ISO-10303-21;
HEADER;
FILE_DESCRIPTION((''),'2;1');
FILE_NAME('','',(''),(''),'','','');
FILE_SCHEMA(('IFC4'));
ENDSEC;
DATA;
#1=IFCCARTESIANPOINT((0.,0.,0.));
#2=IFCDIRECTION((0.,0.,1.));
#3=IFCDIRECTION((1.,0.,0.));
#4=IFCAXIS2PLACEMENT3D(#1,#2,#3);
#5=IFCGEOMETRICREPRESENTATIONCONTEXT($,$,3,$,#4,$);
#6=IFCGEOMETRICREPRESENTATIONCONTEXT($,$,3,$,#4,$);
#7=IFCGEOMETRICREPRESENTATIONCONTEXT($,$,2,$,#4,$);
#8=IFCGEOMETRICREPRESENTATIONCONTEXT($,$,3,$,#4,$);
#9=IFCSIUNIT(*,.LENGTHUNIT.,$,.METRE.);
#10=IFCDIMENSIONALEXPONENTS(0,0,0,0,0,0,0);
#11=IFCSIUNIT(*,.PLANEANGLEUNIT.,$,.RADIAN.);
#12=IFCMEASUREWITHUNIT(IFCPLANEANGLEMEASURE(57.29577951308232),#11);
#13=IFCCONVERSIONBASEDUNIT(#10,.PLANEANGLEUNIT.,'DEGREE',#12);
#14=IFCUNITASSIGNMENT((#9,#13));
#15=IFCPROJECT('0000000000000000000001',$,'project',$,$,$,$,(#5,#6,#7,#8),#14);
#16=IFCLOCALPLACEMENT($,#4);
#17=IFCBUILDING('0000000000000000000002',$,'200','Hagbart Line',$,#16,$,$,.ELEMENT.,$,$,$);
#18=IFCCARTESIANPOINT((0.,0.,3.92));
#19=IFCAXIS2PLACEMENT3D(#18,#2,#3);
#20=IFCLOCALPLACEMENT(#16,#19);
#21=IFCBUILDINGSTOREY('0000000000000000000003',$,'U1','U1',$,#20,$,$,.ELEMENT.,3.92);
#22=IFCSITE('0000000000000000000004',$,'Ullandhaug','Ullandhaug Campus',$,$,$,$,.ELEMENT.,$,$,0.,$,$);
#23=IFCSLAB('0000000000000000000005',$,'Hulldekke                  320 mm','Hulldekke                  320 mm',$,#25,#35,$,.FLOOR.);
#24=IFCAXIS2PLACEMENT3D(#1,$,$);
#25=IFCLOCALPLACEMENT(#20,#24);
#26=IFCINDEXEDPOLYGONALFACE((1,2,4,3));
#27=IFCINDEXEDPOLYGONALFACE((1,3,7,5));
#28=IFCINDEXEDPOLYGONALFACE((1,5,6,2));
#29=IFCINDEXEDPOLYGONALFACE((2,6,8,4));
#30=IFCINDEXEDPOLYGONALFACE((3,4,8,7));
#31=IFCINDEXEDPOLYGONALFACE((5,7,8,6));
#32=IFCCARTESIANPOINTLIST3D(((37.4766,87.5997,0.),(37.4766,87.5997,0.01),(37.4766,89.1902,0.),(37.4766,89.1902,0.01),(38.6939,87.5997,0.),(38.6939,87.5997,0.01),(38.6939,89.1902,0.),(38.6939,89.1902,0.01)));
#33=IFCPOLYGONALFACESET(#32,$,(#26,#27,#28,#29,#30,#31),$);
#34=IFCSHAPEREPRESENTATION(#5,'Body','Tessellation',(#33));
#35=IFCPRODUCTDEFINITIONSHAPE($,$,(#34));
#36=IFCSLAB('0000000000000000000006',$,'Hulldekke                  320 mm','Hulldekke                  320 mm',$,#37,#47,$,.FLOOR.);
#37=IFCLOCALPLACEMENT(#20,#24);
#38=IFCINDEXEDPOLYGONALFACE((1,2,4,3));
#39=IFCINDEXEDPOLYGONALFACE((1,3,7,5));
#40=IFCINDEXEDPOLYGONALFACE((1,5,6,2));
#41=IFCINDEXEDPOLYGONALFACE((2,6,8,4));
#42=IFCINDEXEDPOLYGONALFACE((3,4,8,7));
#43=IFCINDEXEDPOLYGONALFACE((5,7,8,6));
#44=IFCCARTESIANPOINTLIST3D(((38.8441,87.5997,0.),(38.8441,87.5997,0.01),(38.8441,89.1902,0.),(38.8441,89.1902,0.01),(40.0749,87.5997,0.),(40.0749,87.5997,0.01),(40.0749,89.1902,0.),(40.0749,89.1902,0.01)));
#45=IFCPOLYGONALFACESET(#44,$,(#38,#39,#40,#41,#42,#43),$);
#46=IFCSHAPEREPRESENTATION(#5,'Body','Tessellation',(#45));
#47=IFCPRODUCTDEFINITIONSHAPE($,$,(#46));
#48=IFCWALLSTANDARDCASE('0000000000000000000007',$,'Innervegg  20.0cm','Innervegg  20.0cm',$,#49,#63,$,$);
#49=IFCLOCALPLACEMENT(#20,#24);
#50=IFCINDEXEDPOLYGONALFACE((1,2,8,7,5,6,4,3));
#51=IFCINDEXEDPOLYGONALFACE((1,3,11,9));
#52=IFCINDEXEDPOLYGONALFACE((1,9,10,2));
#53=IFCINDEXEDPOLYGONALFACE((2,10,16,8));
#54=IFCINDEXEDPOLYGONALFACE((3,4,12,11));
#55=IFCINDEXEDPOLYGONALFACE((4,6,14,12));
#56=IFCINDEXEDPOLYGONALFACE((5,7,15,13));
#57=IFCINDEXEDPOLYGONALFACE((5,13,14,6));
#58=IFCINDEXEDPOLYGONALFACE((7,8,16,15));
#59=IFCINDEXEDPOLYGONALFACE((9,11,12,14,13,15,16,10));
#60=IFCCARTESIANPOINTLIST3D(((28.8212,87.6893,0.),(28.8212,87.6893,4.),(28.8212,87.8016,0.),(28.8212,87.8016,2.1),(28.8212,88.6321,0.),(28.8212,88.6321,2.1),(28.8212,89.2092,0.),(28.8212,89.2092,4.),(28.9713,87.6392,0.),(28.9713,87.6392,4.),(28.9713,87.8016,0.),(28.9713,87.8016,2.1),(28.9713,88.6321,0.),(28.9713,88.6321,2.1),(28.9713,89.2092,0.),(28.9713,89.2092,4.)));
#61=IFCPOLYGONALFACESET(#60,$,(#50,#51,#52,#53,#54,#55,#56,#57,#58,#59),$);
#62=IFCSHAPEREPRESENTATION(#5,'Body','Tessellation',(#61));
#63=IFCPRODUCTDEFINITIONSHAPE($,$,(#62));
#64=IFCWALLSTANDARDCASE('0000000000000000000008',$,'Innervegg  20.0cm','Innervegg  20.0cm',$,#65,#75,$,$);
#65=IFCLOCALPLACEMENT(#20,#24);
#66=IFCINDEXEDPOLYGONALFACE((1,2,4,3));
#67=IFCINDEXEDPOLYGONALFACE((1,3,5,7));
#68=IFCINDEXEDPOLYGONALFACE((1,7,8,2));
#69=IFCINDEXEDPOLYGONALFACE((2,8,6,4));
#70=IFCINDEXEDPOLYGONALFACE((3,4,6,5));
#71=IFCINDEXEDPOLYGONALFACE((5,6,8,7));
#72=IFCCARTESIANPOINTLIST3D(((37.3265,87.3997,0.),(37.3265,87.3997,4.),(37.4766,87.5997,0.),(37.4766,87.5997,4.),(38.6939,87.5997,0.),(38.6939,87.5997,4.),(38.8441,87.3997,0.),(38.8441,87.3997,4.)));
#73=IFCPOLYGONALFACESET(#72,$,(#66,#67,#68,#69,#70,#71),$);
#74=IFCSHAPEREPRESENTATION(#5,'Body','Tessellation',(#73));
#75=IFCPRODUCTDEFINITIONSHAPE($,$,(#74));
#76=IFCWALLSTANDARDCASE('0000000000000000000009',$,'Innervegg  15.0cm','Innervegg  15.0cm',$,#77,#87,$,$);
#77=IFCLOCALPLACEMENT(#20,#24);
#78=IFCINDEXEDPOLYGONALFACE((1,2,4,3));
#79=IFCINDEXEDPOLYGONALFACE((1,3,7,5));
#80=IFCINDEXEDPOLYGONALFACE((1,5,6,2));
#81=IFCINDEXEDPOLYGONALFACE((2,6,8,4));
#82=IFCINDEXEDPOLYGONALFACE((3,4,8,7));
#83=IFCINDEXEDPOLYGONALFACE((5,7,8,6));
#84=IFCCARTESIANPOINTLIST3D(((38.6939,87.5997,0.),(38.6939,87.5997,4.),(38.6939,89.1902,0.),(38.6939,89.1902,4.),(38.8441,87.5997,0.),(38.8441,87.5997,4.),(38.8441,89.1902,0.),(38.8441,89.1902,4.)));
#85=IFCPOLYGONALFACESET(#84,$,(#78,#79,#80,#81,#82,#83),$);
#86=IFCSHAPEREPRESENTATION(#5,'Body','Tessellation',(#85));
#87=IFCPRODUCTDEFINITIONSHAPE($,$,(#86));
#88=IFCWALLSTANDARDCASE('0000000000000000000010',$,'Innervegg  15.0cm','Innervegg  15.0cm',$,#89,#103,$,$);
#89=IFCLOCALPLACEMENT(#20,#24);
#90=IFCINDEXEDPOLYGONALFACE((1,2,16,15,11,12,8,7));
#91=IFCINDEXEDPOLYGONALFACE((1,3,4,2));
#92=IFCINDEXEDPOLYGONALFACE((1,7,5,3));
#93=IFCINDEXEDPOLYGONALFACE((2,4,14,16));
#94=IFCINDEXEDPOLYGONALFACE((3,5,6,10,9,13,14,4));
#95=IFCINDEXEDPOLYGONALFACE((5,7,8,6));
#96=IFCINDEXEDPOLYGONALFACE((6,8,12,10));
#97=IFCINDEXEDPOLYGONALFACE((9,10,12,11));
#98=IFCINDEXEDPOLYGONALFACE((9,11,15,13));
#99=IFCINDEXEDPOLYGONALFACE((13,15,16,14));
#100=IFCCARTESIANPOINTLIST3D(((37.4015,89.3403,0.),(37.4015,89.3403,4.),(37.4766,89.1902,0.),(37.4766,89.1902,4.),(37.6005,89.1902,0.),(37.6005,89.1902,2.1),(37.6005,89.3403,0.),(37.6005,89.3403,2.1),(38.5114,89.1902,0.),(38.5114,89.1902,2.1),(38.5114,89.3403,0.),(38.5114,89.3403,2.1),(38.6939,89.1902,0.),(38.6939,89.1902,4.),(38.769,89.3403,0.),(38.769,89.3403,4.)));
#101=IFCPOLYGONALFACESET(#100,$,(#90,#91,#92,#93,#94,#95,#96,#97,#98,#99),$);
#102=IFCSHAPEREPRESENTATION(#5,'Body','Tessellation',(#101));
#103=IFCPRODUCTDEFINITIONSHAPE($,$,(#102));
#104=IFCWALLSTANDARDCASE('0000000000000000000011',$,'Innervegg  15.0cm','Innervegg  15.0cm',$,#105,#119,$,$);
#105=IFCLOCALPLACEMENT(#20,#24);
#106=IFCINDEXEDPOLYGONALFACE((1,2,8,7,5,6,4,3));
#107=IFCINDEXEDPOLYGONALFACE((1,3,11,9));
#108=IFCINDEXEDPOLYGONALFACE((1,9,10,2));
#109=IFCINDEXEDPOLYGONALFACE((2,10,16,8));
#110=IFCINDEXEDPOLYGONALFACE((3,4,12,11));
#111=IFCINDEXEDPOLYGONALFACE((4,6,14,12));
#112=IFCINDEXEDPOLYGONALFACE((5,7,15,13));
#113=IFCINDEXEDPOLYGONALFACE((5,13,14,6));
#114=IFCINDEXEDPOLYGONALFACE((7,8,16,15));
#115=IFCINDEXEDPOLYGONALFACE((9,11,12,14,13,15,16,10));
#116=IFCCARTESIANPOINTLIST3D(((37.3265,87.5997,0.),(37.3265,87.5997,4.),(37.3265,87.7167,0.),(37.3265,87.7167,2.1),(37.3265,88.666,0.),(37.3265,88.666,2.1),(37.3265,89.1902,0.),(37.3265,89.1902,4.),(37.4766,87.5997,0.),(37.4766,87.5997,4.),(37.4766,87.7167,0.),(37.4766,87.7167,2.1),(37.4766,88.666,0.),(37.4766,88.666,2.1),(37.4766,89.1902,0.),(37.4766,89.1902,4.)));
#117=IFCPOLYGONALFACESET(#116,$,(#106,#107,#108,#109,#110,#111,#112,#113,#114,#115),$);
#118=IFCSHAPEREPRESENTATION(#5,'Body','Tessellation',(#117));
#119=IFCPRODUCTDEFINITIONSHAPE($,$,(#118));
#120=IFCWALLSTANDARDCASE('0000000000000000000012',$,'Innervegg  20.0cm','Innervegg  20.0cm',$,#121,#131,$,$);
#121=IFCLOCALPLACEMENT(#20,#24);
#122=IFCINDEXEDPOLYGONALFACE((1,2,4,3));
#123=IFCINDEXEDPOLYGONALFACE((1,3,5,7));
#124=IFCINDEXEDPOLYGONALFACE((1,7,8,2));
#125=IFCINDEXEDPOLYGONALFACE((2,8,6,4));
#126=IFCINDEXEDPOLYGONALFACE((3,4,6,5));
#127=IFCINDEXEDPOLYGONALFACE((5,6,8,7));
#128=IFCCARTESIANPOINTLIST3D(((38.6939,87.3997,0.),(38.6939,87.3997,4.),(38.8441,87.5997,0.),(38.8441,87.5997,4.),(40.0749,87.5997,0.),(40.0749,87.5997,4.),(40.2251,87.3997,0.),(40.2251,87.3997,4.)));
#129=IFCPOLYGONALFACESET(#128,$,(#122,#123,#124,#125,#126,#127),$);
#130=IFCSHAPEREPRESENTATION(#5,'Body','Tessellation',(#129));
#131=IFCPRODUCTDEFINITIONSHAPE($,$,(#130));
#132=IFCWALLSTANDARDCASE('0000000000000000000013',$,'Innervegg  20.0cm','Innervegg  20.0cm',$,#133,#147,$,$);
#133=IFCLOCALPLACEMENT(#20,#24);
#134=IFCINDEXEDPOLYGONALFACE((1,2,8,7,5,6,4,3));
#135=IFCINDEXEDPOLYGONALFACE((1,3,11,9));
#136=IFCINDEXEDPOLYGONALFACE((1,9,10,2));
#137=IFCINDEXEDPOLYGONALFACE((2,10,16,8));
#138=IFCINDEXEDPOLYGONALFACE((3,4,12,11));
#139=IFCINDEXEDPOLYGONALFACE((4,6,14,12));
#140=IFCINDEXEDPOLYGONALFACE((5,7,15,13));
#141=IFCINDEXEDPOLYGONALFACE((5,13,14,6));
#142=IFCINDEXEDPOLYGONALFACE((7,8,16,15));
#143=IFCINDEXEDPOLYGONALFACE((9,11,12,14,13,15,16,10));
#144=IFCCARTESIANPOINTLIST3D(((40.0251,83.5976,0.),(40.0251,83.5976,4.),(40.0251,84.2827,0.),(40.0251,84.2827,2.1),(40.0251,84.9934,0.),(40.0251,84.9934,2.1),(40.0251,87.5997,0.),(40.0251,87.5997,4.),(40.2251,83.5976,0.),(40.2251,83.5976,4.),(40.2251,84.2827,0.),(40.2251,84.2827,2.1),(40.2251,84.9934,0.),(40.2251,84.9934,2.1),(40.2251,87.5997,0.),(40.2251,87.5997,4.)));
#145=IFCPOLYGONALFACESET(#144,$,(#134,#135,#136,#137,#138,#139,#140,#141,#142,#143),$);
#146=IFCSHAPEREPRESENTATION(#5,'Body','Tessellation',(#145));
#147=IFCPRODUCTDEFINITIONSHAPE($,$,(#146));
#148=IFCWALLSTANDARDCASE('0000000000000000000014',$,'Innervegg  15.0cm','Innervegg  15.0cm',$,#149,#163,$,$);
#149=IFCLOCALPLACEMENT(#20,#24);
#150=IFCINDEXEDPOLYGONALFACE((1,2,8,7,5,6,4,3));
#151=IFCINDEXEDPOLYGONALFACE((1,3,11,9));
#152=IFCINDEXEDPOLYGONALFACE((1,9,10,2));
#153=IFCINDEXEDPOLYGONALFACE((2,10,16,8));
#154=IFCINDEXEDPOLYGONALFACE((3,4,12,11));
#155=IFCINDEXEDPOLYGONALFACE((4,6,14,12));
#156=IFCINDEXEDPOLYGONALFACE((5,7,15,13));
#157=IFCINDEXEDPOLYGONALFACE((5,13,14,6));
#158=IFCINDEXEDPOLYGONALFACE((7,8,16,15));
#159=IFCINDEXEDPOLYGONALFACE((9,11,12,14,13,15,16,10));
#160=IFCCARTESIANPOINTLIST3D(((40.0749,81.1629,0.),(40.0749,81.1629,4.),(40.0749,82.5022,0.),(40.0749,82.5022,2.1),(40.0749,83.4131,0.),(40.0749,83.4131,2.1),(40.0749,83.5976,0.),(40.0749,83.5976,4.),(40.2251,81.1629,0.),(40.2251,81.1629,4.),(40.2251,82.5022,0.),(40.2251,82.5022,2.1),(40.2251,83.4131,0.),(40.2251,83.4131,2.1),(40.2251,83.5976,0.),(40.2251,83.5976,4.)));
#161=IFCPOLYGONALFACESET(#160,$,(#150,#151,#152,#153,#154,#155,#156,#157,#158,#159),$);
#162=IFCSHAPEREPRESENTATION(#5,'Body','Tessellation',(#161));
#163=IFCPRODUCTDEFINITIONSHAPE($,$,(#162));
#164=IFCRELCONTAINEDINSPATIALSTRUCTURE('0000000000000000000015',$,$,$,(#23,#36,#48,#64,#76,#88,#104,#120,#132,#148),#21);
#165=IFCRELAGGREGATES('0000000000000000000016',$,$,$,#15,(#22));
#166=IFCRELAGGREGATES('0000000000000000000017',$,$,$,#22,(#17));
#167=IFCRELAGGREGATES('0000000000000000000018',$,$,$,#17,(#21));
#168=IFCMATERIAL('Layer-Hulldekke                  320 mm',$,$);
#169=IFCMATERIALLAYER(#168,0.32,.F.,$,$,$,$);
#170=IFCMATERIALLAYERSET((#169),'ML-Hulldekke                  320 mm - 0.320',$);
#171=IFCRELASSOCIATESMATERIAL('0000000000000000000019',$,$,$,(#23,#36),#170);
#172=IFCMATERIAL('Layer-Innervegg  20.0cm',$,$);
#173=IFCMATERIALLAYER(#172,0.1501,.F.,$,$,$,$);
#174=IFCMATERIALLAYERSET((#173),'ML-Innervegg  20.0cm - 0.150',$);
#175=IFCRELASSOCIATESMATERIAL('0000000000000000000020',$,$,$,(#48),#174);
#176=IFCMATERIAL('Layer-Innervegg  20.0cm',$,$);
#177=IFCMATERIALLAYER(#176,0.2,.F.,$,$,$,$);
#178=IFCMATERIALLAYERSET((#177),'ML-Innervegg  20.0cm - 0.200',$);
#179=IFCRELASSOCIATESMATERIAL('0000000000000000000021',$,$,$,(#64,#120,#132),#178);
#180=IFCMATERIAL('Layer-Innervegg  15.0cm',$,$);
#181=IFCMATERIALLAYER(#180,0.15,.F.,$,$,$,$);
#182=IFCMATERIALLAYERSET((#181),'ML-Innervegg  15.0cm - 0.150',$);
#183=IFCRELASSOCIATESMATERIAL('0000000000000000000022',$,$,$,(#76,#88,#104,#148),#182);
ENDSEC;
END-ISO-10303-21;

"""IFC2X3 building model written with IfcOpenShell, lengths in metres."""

from ifc_helpers import new_model, entity, si_unit, converted_unit, frame, origin_with_axes, place, context, project, spatial, polyline, outline, extrude, material, layer, layer_set, layer_usage, element, save


model = new_model("IFC2X3")

# Units and contexts
context_of_model_1 = context(None, 3, world=origin_with_axes())
context_of_model_2 = context(None, 3, world=origin_with_axes())
context_of_model_3 = context(None, 2, world=origin_with_axes())
context_of_model_4 = context(None, 3, world=origin_with_axes())
ifc_project = project(units=[si_unit("LENGTHUNIT", "METRE"), converted_unit("PLANEANGLEUNIT", "DEGREE", entity("IfcPlaneAngleMeasure", 57.29577951308232), si_unit("PLANEANGLEUNIT", "RADIAN"), dimensions=[0, 0, 0, 0, 0, 0, 0])], contexts=[context_of_model_1, context_of_model_2, context_of_model_3, context_of_model_4])

# Site, building, storey
site = spatial("IfcSite", under=ifc_project, Name="Ullandhaug", Description="Ullandhaug Campus", CompositionType="ELEMENT", RefElevation=0.0)
building_placement = place(None, origin_with_axes())
building = spatial("IfcBuilding", under=site, at=building_placement, Name="200", Description="Hagbart Line", CompositionType="ELEMENT")
storey_placement = place(building_placement, frame((0.0, 0.0, 3.92), z_axis=(0.0, 0.0, 1.0), x_axis=(1.0, 0.0, 0.0)))
storey = spatial("IfcBuildingStorey", under=building, at=storey_placement, Name="U1", Description="U1", CompositionType="ELEMENT", Elevation=3.92)

# Slabs
ifc_material_1 = material(Name="Layer-Hulldekke                  320 mm")
ifc_layer_1 = layer(ifc_material_1, 0.32, ventilated=False)
ifc_layer_set_1 = layer_set([ifc_layer_1], Name="ML-Hulldekke                  320 mm - 0.320")
ifc_layer_usage_1 = layer_usage(ifc_layer_set_1, "AXIS2", "POSITIVE", 0.0)
slab_1_placement = place(storey_placement, frame((37.4766, 87.5997, 0.0), z_axis=(0.0, 0.0, 1.0), x_axis=(1.0, 0.0, 0.0)))
element("IfcSlab", 1, at=slab_1_placement, inside=storey, material=ifc_layer_usage_1, Name="Hulldekke                  320 mm", Description="Hulldekke                  320 mm", PredefinedType="FLOOR", context=context_of_model_1, shape_type="SweptSolid", body=[
    extrude(outline(polyline([(0.0, 0.0), (1.2173, 0.0), (1.2173, 1.5904), (0.0, 1.5904), (0.0, 0.0)])), origin_with_axes(), (0.0, 0.0, 1.0), 0.01),
])
slab_2_placement = place(storey_placement, frame((38.8441, 87.5997, 0.0), z_axis=(0.0, 0.0, 1.0), x_axis=(1.0, 0.0, 0.0)))
element("IfcSlab", 2, at=slab_2_placement, inside=storey, material=ifc_layer_usage_1, Name="Hulldekke                  320 mm", Description="Hulldekke                  320 mm", PredefinedType="FLOOR", context=context_of_model_1, shape_type="SweptSolid", body=[
    extrude(outline(polyline([(0.0, 0.0), (1.2309, 0.0), (1.2309, 1.5904), (0.0, 1.5904), (0.0, 0.0)])), origin_with_axes(), (0.0, 0.0, 1.0), 0.01),
])

# Wall, opening
ifc_material_2 = material(Name="Layer-Innervegg  20.0cm")
ifc_layer_2 = layer(ifc_material_2, 0.1501, ventilated=False)
ifc_layer_set_2 = layer_set([ifc_layer_2], Name="ML-Innervegg  20.0cm - 0.150")
ifc_layer_usage_2 = layer_usage(ifc_layer_set_2, "AXIS2", "POSITIVE", 0.0)
wall_1_placement = place(storey_placement, frame((28.9713, 87.6392, 0.0), z_axis=(0.0, 0.0, 1.0), x_axis=(0.0, 1.0, 0.0)))
wall_1 = element("IfcWallStandardCase", 3, at=wall_1_placement, inside=storey, material=ifc_layer_usage_2, Name="Innervegg  20.0cm", Description="Innervegg  20.0cm", context=context_of_model_1, shape_type="SweptSolid", body=[
    extrude(outline(polyline([(0.0, 0.0), (1.5699, 0.0), (1.5699, 0.1501), (0.05, 0.1501), (0.0, 0.0)])), frame((0.0, 0.0, 0.0), z_axis=(0.0, 0.0, 1.0), x_axis=(1.0, 0.0, 0.0)), (0.0, 0.0, 1.0), 4.0),
])
opening_1_placement = place(wall_1_placement, frame((0.1623, 0.1501, 0.0), z_axis=(0.0, 0.0, 1.0), x_axis=(1.0, 0.0, 0.0)))
element("IfcOpeningElement", 4, at=opening_1_placement, cuts=wall_1, context=context_of_model_1, shape_type="SweptSolid", body=[
    extrude(outline(polyline([(0.0, 0.0), (2.1, 0.0), (2.1, 0.8306), (0.0, 0.8306), (0.0, 0.0)])), frame((0.0, 0.0, 0.0), z_axis=(0.0, 1.0, 0.0), x_axis=(0.0, 0.0, 1.0)), (0.0, 0.0, -1.0), 0.1501),
])

# Walls
ifc_material_3 = material(Name="Layer-Innervegg  20.0cm")
ifc_layer_3 = layer(ifc_material_3, 0.2, ventilated=False)
ifc_layer_set_3 = layer_set([ifc_layer_3], Name="ML-Innervegg  20.0cm - 0.200")
ifc_layer_usage_3 = layer_usage(ifc_layer_set_3, "AXIS2", "POSITIVE", 0.0)
wall_2_placement = place(storey_placement, frame((37.3265, 87.3997, 0.0), z_axis=(0.0, 0.0, 1.0), x_axis=(1.0, 0.0, 0.0)))
element("IfcWallStandardCase", 5, at=wall_2_placement, inside=storey, material=ifc_layer_usage_3, Name="Innervegg  20.0cm", Description="Innervegg  20.0cm", context=context_of_model_1, shape_type="SweptSolid", body=[
    extrude(outline(polyline([(0.0, 0.0), (1.5176, 0.0), (1.3675, 0.2), (0.1502, 0.2), (0.0, 0.0)])), origin_with_axes(), (0.0, 0.0, 1.0), 4.0),
])
ifc_material_4 = material(Name="Layer-Innervegg  15.0cm")
ifc_layer_4 = layer(ifc_material_4, 0.15, ventilated=False)
ifc_layer_set_4 = layer_set([ifc_layer_4], Name="ML-Innervegg  15.0cm - 0.150")
ifc_layer_usage_4 = layer_usage(ifc_layer_set_4, "AXIS2", "POSITIVE", 0.0)
wall_3_placement = place(storey_placement, frame((38.8441, 87.5997, 0.0), z_axis=(0.0, 0.0, 1.0), x_axis=(0.0, 1.0, 0.0)))
element("IfcWallStandardCase", 6, at=wall_3_placement, inside=storey, material=ifc_layer_usage_4, Name="Innervegg  15.0cm", Description="Innervegg  15.0cm", context=context_of_model_1, shape_type="SweptSolid", body=[
    extrude(outline(polyline([(0.0, 0.0), (1.5904, 0.0), (1.5904, 0.1502), (0.0, 0.1502), (0.0, 0.0)])), frame((0.0, 0.0, 0.0), z_axis=(0.0, 0.0, 1.0), x_axis=(1.0, 0.0, 0.0)), (0.0, 0.0, 1.0), 4.0),
])

# Walls, openings
wall_4_placement = place(storey_placement, frame((38.769, 89.3403, 0.0), z_axis=(0.0, 0.0, 1.0), x_axis=(-1.0, 0.0, 0.0)))
wall_4 = element("IfcWallStandardCase", 7, at=wall_4_placement, inside=storey, material=ifc_layer_usage_4, Name="Innervegg  15.0cm", Description="Innervegg  15.0cm", context=context_of_model_1, shape_type="SweptSolid", body=[
    extrude(outline(polyline([(0.0, 0.0), (1.3675, 0.0), (1.2924, 0.1501), (0.0751, 0.1501), (0.0, 0.0)])), frame((0.0, 0.0, 0.0), z_axis=(0.0, 0.0, 1.0), x_axis=(1.0, 0.0, 0.0)), (0.0, 0.0, 1.0), 4.0),
])
opening_2_placement = place(wall_4_placement, frame((0.2576, 0.1501, 0.0), z_axis=(0.0, 0.0, 1.0), x_axis=(1.0, 0.0, 0.0)))
element("IfcOpeningElement", 8, at=opening_2_placement, cuts=wall_4, context=context_of_model_1, shape_type="SweptSolid", body=[
    extrude(outline(polyline([(0.0, 0.0), (2.1, 0.0), (2.1, 0.9109), (0.0, 0.9109), (0.0, 0.0)])), frame((0.0, 0.0, 0.0), z_axis=(0.0, 1.0, 0.0), x_axis=(0.0, 0.0, 1.0)), (0.0, 0.0, -1.0), 0.1501),
])
wall_5_placement = place(storey_placement, frame((37.3265, 89.1902, 0.0), z_axis=(0.0, 0.0, 1.0), x_axis=(0.0, -1.0, 0.0)))
wall_5 = element("IfcWallStandardCase", 9, at=wall_5_placement, inside=storey, material=ifc_layer_usage_4, Name="Innervegg  15.0cm", Description="Innervegg  15.0cm", context=context_of_model_1, shape_type="SweptSolid", body=[
    extrude(outline(polyline([(0.0, 0.0), (1.5904, 0.0), (1.5904, 0.1502), (0.0, 0.1502), (0.0, 0.0)])), frame((0.0, 0.0, 0.0), z_axis=(0.0, 0.0, 1.0), x_axis=(1.0, 0.0, 0.0)), (0.0, 0.0, 1.0), 4.0),
])
opening_3_placement = place(wall_5_placement, frame((0.5241, 0.1502, 0.0), z_axis=(0.0, 0.0, 1.0), x_axis=(1.0, 0.0, 0.0)))
element("IfcOpeningElement", 10, at=opening_3_placement, cuts=wall_5, context=context_of_model_1, shape_type="SweptSolid", body=[
    extrude(outline(polyline([(0.0, 0.0), (2.1, 0.0), (2.1, 0.9494), (0.0, 0.9494), (0.0, 0.0)])), frame((0.0, 0.0, 0.0), z_axis=(0.0, 1.0, 0.0), x_axis=(0.0, 0.0, 1.0)), (0.0, 0.0, -1.0), 0.1502),
])

# Wall
wall_6_placement = place(storey_placement, frame((38.6939, 87.3997, 0.0), z_axis=(0.0, 0.0, 1.0), x_axis=(1.0, 0.0, 0.0)))
element("IfcWallStandardCase", 11, at=wall_6_placement, inside=storey, material=ifc_layer_usage_3, Name="Innervegg  20.0cm", Description="Innervegg  20.0cm", context=context_of_model_1, shape_type="SweptSolid", body=[
    extrude(outline(polyline([(0.0, 0.0), (1.5312, 0.0), (1.381, 0.2), (0.1502, 0.2), (0.0, 0.0)])), origin_with_axes(), (0.0, 0.0, 1.0), 4.0),
])

# Walls, openings
wall_7_placement = place(storey_placement, frame((40.0251, 87.5997, 0.0), z_axis=(0.0, 0.0, 1.0), x_axis=(0.0, -1.0, 0.0)))
wall_7 = element("IfcWallStandardCase", 12, at=wall_7_placement, inside=storey, material=ifc_layer_usage_3, Name="Innervegg  20.0cm", Description="Innervegg  20.0cm", context=context_of_model_1, shape_type="SweptSolid", body=[
    extrude(outline(polyline([(0.0, 0.0), (4.0021, 0.0), (4.0021, 0.2), (0.0, 0.2), (0.0, 0.0)])), frame((0.0, 0.0, 0.0), z_axis=(0.0, 0.0, 1.0), x_axis=(1.0, 0.0, 0.0)), (0.0, 0.0, 1.0), 4.0),
])
opening_4_placement = place(wall_7_placement, frame((2.6064, 0.2, 0.0), z_axis=(0.0, 0.0, 1.0), x_axis=(1.0, 0.0, 0.0)))
element("IfcOpeningElement", 13, at=opening_4_placement, cuts=wall_7, context=context_of_model_1, shape_type="SweptSolid", body=[
    extrude(outline(polyline([(0.0, 0.0), (2.1, 0.0), (2.1, 0.7107), (0.0, 0.7107), (0.0, 0.0)])), frame((0.0, 0.0, 0.0), z_axis=(0.0, 1.0, 0.0), x_axis=(0.0, 0.0, 1.0)), (0.0, 0.0, -1.0), 0.2),
])
wall_8_placement = place(storey_placement, frame((40.0749, 83.5976, 0.0), z_axis=(0.0, 0.0, 1.0), x_axis=(0.0, -1.0, 0.0)))
wall_8 = element("IfcWallStandardCase", 14, at=wall_8_placement, inside=storey, material=ifc_layer_usage_4, Name="Innervegg  15.0cm", Description="Innervegg  15.0cm", context=context_of_model_1, shape_type="SweptSolid", body=[
    extrude(outline(polyline([(0.0, 0.0), (2.4347, 0.0), (2.4347, 0.1502), (0.0, 0.1502), (0.0, 0.0)])), frame((0.0, 0.0, 0.0), z_axis=(0.0, 0.0, 1.0), x_axis=(1.0, 0.0, 0.0)), (0.0, 0.0, 1.0), 4.0),
])
opening_5_placement = place(wall_8_placement, frame((0.1844, 0.1502, 0.0), z_axis=(0.0, 0.0, 1.0), x_axis=(1.0, 0.0, 0.0)))
element("IfcOpeningElement", 15, at=opening_5_placement, cuts=wall_8, context=context_of_model_1, shape_type="SweptSolid", body=[
    extrude(outline(polyline([(0.0, 0.0), (2.1, 0.0), (2.1, 0.9109), (0.0, 0.9109), (0.0, 0.0)])), frame((0.0, 0.0, 0.0), z_axis=(0.0, 1.0, 0.0), x_axis=(0.0, 0.0, 1.0)), (0.0, 0.0, -1.0), 0.1502),
])

save(model, "model.ifc")
